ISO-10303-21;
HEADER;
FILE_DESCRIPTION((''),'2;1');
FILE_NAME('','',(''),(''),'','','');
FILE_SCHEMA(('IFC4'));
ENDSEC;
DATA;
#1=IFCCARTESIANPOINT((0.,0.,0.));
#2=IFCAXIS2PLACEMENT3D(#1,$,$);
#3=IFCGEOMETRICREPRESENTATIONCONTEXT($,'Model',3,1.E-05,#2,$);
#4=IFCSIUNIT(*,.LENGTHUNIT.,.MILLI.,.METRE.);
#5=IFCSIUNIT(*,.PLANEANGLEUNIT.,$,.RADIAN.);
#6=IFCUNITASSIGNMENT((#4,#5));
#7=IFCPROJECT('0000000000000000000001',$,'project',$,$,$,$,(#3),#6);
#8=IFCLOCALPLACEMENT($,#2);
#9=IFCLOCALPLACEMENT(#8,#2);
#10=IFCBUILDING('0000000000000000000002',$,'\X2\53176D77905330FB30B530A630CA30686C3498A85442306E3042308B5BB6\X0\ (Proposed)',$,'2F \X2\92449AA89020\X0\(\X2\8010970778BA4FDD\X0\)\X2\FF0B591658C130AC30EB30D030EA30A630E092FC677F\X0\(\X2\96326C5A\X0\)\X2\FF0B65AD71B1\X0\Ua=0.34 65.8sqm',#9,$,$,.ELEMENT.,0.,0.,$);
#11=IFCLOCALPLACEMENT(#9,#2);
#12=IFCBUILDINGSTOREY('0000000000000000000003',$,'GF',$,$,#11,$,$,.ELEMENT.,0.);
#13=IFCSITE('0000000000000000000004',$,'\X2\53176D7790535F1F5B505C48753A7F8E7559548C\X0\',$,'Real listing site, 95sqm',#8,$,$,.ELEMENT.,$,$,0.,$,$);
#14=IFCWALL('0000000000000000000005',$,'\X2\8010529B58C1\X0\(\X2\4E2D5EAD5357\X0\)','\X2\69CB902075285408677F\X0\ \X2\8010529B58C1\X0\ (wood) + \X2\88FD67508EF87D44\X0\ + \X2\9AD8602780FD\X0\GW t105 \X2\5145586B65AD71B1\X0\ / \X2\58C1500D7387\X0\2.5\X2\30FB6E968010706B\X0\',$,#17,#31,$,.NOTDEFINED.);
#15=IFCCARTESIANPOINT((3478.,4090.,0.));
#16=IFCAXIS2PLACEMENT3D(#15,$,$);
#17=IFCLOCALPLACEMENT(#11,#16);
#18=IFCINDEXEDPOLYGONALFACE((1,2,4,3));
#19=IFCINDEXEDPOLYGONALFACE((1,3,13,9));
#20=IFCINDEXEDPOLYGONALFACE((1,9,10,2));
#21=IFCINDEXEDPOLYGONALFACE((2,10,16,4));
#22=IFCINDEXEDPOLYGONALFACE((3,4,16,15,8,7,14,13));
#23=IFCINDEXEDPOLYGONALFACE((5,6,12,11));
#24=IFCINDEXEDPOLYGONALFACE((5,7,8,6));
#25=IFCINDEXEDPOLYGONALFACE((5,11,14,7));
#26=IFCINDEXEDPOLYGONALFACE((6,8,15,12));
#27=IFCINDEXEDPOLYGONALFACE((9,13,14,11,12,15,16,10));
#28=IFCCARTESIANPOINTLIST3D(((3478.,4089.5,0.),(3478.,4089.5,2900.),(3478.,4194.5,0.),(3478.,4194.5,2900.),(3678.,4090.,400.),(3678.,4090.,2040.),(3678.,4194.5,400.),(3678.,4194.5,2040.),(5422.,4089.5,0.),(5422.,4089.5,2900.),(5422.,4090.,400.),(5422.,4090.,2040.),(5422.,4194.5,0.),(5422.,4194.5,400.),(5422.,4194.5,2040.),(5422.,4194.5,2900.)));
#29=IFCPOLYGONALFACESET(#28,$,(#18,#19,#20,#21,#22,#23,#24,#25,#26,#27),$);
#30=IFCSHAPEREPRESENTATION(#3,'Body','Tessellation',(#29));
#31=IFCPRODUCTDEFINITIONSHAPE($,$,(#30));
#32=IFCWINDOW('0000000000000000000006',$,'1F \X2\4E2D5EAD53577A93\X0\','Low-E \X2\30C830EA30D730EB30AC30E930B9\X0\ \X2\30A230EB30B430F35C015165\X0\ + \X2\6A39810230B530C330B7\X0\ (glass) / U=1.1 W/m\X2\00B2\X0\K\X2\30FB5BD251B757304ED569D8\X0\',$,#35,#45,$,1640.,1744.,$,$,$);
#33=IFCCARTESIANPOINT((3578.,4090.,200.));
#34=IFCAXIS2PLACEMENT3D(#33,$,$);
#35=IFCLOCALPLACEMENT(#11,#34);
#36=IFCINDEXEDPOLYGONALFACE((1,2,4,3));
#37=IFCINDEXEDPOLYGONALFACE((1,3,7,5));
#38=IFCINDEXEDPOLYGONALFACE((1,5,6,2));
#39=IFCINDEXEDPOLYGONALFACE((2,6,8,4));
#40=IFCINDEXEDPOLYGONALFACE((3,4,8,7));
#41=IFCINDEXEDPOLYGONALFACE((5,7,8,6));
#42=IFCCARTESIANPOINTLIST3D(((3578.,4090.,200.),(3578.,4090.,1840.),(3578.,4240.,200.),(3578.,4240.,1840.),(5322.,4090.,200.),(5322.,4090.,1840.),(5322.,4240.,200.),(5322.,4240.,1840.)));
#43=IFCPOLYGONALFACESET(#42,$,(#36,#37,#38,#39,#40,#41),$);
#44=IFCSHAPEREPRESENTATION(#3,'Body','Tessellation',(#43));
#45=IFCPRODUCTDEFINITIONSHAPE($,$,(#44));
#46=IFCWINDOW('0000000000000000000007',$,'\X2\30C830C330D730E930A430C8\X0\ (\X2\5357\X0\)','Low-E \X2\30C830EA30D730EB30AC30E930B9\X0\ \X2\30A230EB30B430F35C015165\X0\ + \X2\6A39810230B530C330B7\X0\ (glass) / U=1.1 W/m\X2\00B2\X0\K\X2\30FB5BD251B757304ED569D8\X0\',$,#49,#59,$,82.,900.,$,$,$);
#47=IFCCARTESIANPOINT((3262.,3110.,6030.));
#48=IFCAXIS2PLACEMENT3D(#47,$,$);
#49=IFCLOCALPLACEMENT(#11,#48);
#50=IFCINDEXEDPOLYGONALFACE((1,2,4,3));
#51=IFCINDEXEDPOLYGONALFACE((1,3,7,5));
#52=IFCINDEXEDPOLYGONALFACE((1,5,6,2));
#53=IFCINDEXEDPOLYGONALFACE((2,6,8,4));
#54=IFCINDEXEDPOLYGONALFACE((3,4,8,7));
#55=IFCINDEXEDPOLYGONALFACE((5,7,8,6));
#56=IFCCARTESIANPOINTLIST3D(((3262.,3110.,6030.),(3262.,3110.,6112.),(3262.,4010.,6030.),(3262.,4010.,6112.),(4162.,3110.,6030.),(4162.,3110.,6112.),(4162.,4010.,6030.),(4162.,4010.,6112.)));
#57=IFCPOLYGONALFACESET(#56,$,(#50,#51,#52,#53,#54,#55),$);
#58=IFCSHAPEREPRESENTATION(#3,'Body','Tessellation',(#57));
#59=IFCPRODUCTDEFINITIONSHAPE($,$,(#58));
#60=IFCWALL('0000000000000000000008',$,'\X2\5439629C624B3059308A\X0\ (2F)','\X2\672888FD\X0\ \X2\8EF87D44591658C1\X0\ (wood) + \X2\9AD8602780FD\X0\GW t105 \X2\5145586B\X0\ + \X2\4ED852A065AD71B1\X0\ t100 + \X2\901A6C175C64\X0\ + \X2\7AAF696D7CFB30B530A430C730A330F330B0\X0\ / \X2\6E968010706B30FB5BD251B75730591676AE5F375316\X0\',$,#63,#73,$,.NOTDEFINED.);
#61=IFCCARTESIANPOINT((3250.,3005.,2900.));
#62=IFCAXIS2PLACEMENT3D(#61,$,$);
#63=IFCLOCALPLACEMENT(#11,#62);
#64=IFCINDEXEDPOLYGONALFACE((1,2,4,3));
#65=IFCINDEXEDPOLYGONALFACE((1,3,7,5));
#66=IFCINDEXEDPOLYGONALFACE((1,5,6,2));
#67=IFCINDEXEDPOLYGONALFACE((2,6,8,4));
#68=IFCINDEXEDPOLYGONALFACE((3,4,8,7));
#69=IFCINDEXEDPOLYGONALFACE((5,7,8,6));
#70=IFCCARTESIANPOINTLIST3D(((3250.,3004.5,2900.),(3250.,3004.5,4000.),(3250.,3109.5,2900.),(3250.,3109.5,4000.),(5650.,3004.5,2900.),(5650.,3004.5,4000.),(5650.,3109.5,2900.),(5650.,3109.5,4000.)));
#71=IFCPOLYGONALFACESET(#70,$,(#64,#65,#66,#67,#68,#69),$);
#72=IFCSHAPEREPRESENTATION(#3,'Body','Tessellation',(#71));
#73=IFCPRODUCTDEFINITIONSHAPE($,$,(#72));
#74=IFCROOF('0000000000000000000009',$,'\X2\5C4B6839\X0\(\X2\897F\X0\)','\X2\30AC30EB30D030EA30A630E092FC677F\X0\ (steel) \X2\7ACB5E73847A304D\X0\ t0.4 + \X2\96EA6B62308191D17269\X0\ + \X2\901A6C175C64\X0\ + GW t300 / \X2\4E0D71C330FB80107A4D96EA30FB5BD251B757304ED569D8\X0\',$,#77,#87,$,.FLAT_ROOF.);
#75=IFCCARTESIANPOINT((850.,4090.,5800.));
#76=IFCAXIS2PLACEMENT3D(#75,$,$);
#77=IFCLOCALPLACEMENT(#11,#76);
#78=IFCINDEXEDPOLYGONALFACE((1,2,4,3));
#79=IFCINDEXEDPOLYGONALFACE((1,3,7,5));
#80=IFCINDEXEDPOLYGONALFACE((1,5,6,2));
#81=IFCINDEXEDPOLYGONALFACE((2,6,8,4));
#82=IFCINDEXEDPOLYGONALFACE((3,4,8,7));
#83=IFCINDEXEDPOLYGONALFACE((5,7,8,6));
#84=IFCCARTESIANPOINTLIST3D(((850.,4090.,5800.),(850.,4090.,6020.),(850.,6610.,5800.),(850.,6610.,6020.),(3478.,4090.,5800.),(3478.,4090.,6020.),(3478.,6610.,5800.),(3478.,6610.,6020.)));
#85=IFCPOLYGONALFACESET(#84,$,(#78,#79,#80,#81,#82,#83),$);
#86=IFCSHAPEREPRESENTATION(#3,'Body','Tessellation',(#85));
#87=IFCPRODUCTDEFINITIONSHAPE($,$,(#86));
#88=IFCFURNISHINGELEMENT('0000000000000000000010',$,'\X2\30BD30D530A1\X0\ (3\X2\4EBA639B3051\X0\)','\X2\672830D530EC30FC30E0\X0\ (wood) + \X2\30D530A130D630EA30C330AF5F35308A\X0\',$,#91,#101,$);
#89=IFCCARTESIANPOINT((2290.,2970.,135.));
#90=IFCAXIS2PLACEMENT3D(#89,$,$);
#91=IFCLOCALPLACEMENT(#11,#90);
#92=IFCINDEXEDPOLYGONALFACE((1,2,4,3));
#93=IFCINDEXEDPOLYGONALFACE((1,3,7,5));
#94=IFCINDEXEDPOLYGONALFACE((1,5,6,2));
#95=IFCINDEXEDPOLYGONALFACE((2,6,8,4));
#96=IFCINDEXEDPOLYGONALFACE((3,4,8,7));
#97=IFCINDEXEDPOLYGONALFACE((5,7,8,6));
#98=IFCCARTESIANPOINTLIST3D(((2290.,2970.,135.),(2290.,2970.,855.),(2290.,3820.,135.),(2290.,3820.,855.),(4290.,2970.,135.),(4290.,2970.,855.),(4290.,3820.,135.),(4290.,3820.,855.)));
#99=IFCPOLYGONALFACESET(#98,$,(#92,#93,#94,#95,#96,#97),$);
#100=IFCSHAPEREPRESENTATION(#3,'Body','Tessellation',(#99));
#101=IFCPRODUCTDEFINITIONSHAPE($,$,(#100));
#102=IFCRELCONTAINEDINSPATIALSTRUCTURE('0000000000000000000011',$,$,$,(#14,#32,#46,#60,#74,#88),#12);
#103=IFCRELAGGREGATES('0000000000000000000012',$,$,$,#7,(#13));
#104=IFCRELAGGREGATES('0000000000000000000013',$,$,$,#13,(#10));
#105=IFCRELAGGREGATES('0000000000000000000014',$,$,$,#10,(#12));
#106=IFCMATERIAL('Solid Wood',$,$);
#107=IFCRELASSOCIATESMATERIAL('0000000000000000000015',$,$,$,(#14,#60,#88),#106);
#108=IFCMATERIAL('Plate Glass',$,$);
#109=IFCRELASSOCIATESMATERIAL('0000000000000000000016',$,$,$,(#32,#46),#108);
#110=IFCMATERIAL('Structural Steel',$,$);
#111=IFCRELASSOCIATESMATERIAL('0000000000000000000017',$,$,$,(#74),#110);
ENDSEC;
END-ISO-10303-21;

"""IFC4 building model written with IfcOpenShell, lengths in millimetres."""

from ifc_helpers import new_model, si_unit, frame, frame_2d, origin, place, context, project, spatial, rectangle, extrude, material, element, fill, save


model = new_model("IFC4")

# Units and contexts
model_context = context("Model", 3, precision=1e-05, world=origin())
ifc_project = project(units=[si_unit("LENGTHUNIT", "METRE", prefix="MILLI"), si_unit("PLANEANGLEUNIT", "RADIAN")], contexts=[model_context])

# Site, building, storey
site_placement = place(None, origin())
site = spatial("IfcSite", under=ifc_project, at=site_placement, Name="北海道弟子屈町美留和", ObjectType="Real listing site, 95sqm", CompositionType="ELEMENT", RefElevation=0.0)
building_placement = place(site_placement, origin())
building = spatial("IfcBuilding", under=site, at=building_placement, Name="北海道・サウナと水風呂のある家 (Proposed)", ObjectType="2F 鉄骨造(耐震確保)＋外壁ガルバリウム鋼板(防汚)＋断熱Ua=0.34 65.8sqm", CompositionType="ELEMENT", ElevationOfRefHeight=0.0, ElevationOfTerrain=0.0)
storey_placement = place(building_placement, origin())
storey = spatial("IfcBuildingStorey", under=building, at=storey_placement, Name="GF", CompositionType="ELEMENT", Elevation=0.0)

# Shared definitions
ifc_material_1 = material(Name="Solid Wood")

# Wall, opening, window
wall_1_placement = place(storey_placement, frame((3478.0, 4090.0, 0.0)))
wall_1 = element("IfcWall", 1, at=wall_1_placement, inside=storey, material=ifc_material_1, Name="耐力壁(中庭南)", Description="構造用合板 耐力壁 (wood) + 製材軸組 + 高性能GW t105 充填断熱 / 壁倍率2.5・準耐火", PredefinedType="NOTDEFINED", context=model_context, shape_type="SweptSolid", body=[
    extrude(rectangle(XDim=1944.0, YDim=105.0, at=frame_2d((972.0, 52.0))), frame((3478.0, 4090.0, 0.0)), (0.0, 0.0, 1.0), 2900.0),
])
opening_placement = place(storey_placement, frame((3578.0, 4090.0, 200.0)))
opening = element("IfcOpeningElement", 2, at=opening_placement, cuts=wall_1, PredefinedType="NOTDEFINED", context=model_context, shape_type="SweptSolid", body=[
    extrude(rectangle(XDim=1744.0, YDim=150.0, at=frame_2d((872.0, 75.0))), frame((3578.0, 4090.0, 200.0)), (0.0, 0.0, 1.0), 1640.0),
])
ifc_material_2 = material(Name="Plate Glass")
window_1_placement = place(storey_placement, frame((3578.0, 4090.0, 200.0)))
window_1 = element("IfcWindow", 3, at=window_1_placement, inside=storey, material=ifc_material_2, Name="1F 中庭南窓", Description="Low-E トリプルガラス アルゴン封入 + 樹脂サッシ (glass) / U=1.1 W/m²K・寒冷地仕様", OverallHeight=1640.0, OverallWidth=1744.0, context=model_context, shape_type="SweptSolid", body=[
    extrude(rectangle(XDim=1744.0, YDim=150.0, at=frame_2d((872.0, 75.0))), frame((3578.0, 4090.0, 200.0)), (0.0, 0.0, 1.0), 1640.0),
])
fill(opening, window_1)

# Window
window_2_placement = place(storey_placement, frame((3262.0, 3110.0, 6030.0)))
element("IfcWindow", 4, at=window_2_placement, inside=storey, material=ifc_material_2, Name="トップライト (南)", Description="Low-E トリプルガラス アルゴン封入 + 樹脂サッシ (glass) / U=1.1 W/m²K・寒冷地仕様", OverallHeight=82.0, OverallWidth=900.0, context=model_context, shape_type="SweptSolid", body=[
    extrude(rectangle(XDim=900.0, YDim=900.0, at=frame_2d((450.0, 450.0))), frame((3262.0, 3110.0, 6030.0)), (0.0, 0.0, 1.0), 82.0),
])

# Wall
wall_2_placement = place(storey_placement, frame((3250.0, 3005.0, 2900.0)))
element("IfcWall", 5, at=wall_2_placement, inside=storey, material=ifc_material_1, Name="吹抜手すり (2F)", Description="木製 軸組外壁 (wood) + 高性能GW t105 充填 + 付加断熱 t100 + 通気層 + 窯業系サイディング / 準耐火・寒冷地外皮強化", PredefinedType="NOTDEFINED", context=model_context, shape_type="SweptSolid", body=[
    extrude(rectangle(XDim=2400.0, YDim=105.0, at=frame_2d((1200.0, 52.0))), frame((3250.0, 3005.0, 2900.0)), (0.0, 0.0, 1.0), 1100.0),
])

# Roof
ifc_material_3 = material(Name="Structural Steel")
for number, where, name in (
    (6, (850.0, 4090.0, 5800.0), "屋根(西)"),
):
    element("IfcRoof", number, at=place(storey_placement, frame(where)), inside=storey, material=ifc_material_3, Name=name, Description="ガルバリウム鋼板 (steel) 立平葺き t0.4 + 雪止め金物 + 通気層 + GW t300 / 不燃・耐積雪・寒冷地仕様", PredefinedType="FLAT_ROOF", context=model_context, shape_type="SweptSolid", body=[
        extrude(rectangle(XDim=2628.0, YDim=2520.0, at=frame_2d((1314.0, 1260.0))), frame((850.0, 4090.0, 5800.0)), (0.0, 0.0, 1.0), 220.0),
    ])

# Furnishing element
furnishing_placement = place(storey_placement, frame((2290.0, 2970.0, 135.0)))
element("IfcFurnishingElement", 7, at=furnishing_placement, inside=storey, material=ifc_material_1, Name="ソファ (3人掛け)", Description="木フレーム (wood) + ファブリック張り", context=model_context, shape_type="SweptSolid", body=[
    extrude(rectangle(XDim=2000.0, YDim=850.0, at=frame_2d((1000.0, 425.0))), frame((2290.0, 2970.0, 135.0)), (0.0, 0.0, 1.0), 720.0),
])

save(model, "model.ifc")
